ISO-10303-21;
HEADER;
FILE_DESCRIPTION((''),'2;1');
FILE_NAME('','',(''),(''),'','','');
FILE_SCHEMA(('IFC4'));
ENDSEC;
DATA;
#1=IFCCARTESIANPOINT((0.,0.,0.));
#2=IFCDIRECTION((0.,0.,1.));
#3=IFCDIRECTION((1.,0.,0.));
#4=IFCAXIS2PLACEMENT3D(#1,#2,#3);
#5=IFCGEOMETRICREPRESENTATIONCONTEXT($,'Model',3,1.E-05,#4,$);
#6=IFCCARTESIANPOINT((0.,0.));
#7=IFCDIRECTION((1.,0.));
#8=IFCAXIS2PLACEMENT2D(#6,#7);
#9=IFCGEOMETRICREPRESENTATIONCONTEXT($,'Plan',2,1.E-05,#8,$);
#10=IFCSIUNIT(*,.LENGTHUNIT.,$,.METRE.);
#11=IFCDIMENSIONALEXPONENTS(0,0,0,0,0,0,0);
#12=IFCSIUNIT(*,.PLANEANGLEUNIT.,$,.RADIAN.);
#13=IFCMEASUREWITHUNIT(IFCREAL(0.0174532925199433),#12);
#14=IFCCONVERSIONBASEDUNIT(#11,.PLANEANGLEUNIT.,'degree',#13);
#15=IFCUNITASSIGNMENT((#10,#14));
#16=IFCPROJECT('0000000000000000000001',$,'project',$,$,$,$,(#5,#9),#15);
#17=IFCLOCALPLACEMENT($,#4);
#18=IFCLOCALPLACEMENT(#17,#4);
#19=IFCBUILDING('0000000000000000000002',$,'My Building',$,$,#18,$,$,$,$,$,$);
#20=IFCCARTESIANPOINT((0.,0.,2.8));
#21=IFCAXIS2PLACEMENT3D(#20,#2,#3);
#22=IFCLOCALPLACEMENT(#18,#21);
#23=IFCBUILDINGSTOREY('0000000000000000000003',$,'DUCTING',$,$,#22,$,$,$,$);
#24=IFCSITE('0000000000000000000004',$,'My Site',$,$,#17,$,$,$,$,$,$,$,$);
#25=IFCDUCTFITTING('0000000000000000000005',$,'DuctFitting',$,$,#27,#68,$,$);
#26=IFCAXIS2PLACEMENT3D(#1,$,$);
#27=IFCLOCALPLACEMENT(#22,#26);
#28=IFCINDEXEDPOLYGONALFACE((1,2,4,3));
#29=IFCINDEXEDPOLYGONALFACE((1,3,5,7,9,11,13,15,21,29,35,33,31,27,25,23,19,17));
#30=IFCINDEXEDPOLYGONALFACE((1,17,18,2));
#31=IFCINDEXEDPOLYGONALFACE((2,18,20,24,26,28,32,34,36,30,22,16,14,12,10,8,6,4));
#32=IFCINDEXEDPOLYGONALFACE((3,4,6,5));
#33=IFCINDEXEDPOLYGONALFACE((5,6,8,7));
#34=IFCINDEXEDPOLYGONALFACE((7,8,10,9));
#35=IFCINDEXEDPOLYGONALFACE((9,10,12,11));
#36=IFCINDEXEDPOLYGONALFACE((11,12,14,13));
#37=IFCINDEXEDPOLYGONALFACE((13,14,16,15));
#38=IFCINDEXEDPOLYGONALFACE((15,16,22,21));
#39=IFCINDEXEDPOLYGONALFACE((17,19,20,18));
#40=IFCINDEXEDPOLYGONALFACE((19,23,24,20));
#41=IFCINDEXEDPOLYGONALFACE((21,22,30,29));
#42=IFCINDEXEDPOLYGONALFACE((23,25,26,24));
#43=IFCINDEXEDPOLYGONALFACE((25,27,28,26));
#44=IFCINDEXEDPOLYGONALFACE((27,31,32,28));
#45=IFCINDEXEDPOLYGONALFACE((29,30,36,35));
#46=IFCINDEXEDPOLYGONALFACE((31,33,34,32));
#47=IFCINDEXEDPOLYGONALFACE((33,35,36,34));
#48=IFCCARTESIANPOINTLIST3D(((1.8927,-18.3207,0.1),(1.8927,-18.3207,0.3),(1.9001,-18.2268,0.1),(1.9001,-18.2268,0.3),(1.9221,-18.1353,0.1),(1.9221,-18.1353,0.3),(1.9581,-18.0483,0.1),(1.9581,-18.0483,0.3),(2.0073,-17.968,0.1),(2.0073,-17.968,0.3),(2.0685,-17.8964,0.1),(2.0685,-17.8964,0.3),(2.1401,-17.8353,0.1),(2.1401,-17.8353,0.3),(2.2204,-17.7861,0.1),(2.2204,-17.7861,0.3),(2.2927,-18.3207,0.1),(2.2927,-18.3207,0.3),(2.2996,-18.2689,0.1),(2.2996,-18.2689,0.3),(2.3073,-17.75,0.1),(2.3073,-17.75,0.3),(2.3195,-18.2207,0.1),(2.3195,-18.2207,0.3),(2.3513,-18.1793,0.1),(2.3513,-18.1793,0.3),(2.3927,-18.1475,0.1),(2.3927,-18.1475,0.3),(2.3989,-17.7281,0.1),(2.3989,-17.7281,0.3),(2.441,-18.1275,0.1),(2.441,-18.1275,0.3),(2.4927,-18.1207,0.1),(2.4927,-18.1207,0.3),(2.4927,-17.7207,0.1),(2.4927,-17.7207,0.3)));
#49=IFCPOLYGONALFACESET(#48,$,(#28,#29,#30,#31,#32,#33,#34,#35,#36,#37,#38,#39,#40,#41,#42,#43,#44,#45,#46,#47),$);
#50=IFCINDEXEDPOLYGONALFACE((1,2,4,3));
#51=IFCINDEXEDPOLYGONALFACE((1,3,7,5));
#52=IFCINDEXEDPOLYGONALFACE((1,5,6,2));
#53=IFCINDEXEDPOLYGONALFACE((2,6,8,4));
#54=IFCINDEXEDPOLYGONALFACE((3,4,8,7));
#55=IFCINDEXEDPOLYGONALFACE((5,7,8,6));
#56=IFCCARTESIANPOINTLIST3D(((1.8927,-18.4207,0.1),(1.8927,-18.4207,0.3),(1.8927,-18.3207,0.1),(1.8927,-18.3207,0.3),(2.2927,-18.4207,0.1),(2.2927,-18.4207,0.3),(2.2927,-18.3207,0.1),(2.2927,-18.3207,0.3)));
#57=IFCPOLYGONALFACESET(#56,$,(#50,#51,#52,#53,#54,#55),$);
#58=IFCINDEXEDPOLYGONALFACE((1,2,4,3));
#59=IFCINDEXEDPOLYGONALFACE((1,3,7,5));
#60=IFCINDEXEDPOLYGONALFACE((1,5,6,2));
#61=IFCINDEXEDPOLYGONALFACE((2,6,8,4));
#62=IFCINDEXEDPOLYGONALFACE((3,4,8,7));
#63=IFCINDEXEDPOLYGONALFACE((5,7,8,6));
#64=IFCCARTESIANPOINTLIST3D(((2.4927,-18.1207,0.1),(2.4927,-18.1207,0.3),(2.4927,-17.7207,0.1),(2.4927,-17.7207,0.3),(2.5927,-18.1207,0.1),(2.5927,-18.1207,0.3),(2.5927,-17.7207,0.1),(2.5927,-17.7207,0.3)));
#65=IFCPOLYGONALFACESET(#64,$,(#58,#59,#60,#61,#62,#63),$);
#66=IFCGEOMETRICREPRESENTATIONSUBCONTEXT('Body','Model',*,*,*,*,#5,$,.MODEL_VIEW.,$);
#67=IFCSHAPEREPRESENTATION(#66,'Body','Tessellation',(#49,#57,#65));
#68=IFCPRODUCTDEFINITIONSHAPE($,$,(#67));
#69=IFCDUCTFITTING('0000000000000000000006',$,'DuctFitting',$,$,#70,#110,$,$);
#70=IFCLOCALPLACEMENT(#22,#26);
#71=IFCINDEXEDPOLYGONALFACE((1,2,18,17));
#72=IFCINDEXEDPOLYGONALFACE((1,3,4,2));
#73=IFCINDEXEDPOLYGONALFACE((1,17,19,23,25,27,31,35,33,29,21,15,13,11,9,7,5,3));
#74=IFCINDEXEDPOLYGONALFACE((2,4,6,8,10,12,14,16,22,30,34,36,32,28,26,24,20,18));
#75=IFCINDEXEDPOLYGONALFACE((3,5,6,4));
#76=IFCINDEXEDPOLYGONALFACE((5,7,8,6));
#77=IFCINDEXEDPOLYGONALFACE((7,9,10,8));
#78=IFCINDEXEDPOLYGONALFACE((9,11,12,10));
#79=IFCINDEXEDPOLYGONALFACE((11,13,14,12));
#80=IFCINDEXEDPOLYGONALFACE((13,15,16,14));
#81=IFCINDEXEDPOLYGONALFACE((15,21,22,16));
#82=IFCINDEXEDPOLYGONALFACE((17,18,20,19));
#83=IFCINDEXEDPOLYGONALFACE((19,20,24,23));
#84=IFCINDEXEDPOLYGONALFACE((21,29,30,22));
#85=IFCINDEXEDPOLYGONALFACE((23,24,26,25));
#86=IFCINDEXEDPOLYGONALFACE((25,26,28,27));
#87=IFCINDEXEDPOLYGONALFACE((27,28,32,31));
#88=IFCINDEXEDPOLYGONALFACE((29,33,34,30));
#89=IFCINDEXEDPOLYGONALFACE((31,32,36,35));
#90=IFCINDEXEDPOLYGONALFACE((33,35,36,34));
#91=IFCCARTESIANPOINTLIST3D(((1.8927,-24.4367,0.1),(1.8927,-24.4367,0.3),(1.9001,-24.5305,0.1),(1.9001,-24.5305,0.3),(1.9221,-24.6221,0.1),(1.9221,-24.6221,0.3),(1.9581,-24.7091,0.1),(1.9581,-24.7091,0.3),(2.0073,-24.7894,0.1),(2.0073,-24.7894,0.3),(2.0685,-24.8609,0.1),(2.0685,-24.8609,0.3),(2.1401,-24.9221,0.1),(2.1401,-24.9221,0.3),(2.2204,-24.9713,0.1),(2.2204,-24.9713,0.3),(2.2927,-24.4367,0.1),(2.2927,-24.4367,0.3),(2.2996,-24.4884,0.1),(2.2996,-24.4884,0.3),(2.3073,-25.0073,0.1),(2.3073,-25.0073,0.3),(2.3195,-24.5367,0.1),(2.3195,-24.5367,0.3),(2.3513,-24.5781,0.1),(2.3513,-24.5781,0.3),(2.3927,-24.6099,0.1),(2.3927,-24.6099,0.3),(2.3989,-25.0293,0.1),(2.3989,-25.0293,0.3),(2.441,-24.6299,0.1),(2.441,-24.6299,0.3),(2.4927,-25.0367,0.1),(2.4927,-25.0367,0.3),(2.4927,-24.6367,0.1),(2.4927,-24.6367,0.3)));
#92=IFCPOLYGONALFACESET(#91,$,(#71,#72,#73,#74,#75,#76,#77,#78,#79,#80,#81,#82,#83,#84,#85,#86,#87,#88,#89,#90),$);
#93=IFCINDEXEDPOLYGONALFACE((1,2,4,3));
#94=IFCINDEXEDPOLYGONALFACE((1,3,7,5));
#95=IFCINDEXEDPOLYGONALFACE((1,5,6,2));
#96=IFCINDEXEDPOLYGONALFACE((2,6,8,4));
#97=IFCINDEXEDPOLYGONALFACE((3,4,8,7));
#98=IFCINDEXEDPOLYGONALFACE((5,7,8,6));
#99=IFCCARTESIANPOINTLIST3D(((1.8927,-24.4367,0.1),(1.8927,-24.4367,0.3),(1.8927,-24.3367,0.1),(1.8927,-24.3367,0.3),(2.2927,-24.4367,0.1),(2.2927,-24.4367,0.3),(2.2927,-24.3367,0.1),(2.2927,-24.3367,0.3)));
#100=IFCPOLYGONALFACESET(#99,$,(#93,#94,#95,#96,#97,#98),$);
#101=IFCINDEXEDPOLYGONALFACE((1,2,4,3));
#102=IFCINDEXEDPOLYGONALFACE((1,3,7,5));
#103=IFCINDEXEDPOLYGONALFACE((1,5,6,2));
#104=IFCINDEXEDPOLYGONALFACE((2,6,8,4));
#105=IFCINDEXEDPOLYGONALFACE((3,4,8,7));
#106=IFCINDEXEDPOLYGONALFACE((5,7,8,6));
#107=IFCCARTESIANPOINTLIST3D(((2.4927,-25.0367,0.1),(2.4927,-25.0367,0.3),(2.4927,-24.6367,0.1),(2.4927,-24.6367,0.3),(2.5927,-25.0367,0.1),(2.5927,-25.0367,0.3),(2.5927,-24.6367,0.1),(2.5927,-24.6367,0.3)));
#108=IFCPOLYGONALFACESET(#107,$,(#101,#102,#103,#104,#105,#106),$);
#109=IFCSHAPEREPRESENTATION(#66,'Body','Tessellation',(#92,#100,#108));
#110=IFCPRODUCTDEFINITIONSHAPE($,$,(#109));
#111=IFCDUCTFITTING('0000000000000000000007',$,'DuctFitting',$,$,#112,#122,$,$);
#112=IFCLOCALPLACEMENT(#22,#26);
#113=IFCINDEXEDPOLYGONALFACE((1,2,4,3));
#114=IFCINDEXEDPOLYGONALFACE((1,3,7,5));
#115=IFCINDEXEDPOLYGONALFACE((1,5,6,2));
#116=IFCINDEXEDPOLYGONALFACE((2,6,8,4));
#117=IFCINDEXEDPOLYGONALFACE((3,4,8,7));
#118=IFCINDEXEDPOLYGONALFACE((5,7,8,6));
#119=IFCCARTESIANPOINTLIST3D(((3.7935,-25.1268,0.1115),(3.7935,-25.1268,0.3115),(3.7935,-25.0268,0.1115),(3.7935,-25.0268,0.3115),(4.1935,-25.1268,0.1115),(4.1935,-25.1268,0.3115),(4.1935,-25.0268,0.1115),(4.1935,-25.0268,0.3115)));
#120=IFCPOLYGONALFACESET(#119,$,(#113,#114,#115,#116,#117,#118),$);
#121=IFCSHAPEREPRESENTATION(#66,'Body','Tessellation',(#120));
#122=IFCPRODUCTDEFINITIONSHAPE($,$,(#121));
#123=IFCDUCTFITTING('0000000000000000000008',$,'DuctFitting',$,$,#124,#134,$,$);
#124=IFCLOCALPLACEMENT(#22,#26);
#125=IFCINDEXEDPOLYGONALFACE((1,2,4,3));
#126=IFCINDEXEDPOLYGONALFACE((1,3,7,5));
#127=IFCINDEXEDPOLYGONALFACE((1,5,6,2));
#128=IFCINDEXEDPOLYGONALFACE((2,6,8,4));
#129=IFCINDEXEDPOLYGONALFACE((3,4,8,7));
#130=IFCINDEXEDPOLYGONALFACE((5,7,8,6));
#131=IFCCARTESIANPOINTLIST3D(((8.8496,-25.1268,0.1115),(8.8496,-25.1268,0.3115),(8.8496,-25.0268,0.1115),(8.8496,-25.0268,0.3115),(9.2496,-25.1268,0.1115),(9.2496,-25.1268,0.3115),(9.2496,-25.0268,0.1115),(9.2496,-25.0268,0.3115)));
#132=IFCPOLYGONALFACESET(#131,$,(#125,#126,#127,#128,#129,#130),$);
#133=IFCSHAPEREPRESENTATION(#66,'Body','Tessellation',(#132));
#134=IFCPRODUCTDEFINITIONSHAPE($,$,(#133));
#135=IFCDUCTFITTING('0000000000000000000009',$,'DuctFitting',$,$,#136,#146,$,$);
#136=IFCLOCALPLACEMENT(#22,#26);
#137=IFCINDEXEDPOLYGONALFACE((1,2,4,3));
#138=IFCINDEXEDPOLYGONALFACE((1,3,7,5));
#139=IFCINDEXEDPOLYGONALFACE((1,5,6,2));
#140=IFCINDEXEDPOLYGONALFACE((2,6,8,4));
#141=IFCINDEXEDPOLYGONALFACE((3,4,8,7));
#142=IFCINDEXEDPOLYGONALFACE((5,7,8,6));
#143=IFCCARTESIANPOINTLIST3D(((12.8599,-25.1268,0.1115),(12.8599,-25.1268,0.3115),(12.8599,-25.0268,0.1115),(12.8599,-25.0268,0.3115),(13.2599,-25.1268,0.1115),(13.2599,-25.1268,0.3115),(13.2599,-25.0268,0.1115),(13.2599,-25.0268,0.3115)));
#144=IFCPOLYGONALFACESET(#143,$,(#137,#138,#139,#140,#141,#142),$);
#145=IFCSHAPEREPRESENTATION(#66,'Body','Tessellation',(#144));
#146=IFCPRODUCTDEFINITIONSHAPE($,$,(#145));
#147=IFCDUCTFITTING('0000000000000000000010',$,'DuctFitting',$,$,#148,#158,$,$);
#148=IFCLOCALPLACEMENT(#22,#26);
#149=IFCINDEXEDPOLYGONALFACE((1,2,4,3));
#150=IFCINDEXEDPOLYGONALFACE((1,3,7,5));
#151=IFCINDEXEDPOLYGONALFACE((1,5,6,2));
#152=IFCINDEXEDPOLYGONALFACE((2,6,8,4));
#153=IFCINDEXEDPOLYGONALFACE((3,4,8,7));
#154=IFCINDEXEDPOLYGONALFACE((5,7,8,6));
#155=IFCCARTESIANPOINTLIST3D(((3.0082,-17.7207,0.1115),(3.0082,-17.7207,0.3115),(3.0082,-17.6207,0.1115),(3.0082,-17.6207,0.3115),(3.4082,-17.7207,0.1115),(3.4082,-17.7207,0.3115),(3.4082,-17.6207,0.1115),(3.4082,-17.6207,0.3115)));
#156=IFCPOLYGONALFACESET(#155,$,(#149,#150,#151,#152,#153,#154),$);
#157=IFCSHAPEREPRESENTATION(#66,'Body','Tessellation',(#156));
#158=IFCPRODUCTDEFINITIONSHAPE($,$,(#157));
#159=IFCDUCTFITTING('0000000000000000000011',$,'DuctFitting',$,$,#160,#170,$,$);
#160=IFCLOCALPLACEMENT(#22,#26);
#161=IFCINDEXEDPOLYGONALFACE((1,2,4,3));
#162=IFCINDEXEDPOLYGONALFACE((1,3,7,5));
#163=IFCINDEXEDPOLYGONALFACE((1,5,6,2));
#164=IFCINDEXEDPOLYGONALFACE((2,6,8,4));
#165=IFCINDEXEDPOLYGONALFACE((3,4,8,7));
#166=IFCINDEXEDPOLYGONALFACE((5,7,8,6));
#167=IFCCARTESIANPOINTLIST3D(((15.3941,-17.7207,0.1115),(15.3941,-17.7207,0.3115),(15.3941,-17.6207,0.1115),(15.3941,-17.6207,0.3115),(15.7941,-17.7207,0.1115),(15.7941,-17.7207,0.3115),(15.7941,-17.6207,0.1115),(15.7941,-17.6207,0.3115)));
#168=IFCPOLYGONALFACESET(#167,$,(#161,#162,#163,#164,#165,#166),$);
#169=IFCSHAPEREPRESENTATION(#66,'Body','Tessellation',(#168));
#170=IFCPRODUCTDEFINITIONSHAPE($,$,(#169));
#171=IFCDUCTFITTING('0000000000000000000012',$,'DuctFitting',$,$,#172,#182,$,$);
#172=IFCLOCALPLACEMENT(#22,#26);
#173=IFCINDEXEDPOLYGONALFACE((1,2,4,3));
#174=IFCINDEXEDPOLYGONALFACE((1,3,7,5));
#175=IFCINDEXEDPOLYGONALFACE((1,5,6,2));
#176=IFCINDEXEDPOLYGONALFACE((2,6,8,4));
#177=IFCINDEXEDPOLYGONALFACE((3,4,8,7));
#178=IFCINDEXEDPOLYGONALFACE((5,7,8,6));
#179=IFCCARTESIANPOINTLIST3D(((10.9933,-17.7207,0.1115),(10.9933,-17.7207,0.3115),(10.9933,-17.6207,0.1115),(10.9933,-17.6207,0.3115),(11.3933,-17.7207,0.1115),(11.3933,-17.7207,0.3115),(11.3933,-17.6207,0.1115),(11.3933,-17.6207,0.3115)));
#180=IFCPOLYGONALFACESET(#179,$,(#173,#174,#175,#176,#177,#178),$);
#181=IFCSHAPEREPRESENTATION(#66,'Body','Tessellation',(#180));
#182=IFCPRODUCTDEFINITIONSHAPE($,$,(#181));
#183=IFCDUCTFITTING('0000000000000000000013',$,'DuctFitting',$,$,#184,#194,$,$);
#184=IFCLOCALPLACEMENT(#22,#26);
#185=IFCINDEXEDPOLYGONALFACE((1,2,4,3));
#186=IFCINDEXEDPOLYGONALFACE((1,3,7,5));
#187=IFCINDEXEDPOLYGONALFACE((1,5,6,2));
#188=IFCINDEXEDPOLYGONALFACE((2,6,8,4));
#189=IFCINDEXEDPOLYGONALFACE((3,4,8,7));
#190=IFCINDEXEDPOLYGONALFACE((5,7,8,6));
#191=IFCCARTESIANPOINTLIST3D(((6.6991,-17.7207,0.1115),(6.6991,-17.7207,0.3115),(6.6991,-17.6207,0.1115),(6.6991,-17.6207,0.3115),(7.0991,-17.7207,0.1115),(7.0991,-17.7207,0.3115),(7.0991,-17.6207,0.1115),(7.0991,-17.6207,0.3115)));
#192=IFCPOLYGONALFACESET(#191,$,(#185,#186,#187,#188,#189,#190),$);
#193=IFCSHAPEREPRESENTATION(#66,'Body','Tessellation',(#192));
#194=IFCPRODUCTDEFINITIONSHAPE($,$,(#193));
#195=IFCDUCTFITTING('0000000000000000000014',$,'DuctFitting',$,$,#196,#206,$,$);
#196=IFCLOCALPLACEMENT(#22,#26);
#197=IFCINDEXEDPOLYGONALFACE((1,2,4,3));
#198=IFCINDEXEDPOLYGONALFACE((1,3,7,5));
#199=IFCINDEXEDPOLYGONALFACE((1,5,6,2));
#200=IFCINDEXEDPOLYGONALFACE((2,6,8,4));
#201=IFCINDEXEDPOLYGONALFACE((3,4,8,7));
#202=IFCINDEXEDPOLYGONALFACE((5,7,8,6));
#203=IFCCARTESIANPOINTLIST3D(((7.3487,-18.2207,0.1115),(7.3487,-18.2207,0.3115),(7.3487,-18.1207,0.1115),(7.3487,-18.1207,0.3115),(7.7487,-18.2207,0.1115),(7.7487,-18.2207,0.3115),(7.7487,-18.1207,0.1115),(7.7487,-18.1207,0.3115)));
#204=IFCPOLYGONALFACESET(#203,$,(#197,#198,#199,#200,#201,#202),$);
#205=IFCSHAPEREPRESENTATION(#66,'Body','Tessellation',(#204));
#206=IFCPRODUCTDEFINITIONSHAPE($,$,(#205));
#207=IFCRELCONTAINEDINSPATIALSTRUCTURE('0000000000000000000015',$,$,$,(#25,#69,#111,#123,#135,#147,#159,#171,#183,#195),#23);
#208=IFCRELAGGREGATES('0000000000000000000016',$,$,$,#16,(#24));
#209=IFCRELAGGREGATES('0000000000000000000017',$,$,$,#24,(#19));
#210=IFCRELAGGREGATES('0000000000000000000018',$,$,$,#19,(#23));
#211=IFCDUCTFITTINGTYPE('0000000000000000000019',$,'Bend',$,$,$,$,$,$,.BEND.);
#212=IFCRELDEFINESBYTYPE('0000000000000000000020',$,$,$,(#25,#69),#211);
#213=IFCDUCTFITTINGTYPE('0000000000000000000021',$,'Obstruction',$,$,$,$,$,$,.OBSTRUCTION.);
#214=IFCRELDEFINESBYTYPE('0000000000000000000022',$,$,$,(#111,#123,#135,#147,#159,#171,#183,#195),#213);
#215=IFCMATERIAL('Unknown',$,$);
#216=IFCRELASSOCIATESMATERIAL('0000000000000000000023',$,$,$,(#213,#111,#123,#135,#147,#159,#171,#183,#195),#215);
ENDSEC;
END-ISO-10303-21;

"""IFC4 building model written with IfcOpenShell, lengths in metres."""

from ifc_helpers import new_model, entity, si_unit, converted_unit, frame, origin_with_axes, origin_2d_with_axis, place, context, subcontext, project, spatial, line, arc, indexed_curve, rectangle, outline, extrude, source, transform, mapped, material, material_profile, profile_set, profile_usage, type_object, type_shapes, element, save


model = new_model("IFC4")

# Units and contexts
model_context = context("Model", 3, precision=1e-05, world=origin_with_axes())
plan_context = context("Plan", 2, precision=1e-05, world=origin_2d_with_axis())
body_context = subcontext(model_context, "Body", "Model", "MODEL_VIEW")
ifc_project = project(units=[si_unit("LENGTHUNIT", "METRE"), converted_unit("PLANEANGLEUNIT", "degree", entity("IfcReal", 0.0174532925199433), si_unit("PLANEANGLEUNIT", "RADIAN"), dimensions=[0, 0, 0, 0, 0, 0, 0])], contexts=[model_context, plan_context])

# Site, building, storey
site_placement = place(None, origin_with_axes())
site = spatial("IfcSite", under=ifc_project, at=site_placement, Name="My Site")
building_placement = place(site_placement, origin_with_axes())
building = spatial("IfcBuilding", under=site, at=building_placement, Name="My Building")
storey_placement = place(building_placement, frame((0.0, 0.0, 2.8), z_axis=(0.0, 0.0, 1.0), x_axis=(1.0, 0.0, 0.0)))
storey = spatial("IfcBuildingStorey", under=building, at=storey_placement, Name="DUCTING")

# Shared definitions
ifc_material = material(Name="Unknown")

# Duct fittings
duct_fitting_type_1 = type_object("IfcDuctFittingType", Name="Bend", PredefinedType="BEND")
shared_shape = source(origin_with_axes(), body_context, "Body", "SweptSolid", [
    extrude(outline(indexed_curve([(-0.2, 0.0), (-0.2586, -0.1414), (-0.4, -0.2), (-0.4, -0.6), (0.0243, -0.4243), (0.2, 0.0)], segments=[arc(1, 2, 3), line(3, 4), arc(4, 5, 6), line(6, 1)])), frame((0.0, -0.1, -0.1), z_axis=(0.0, -1.0, 0.0), x_axis=(1.0, 0.0, 0.0)), (0.0, 0.0, -1.0), 0.2),
    extrude(rectangle(XDim=0.4, YDim=0.2), origin_with_axes(), (0.0, 0.0, -1.0), 0.1),
    extrude(rectangle(XDim=0.4, YDim=0.2), frame((-0.4, 0.0, -0.5), z_axis=(-1.0, 0.0, 0.0), x_axis=(0.0, 0.0, -1.0)), (0.0, 0.0, 1.0), 0.1),
])
type_shapes(duct_fitting_type_1, [shared_shape])
for number, where, z_axis, x_axis, name in (
    (1, (2.0927, -18.4207, 0.2), (0.0, -1.0, 0.0), (-1.0, 0.0, 0.0), "DuctFitting"),
    (2, (2.0927, -24.3367, 0.2), (0.0, 1.0, 0.0), (-1.0, 0.0, 0.0), "DuctFitting"),
):
    element("IfcDuctFitting", number, at=place(storey_placement, frame(where, z_axis=z_axis, x_axis=x_axis)), inside=storey, type_object=duct_fitting_type_1, Name=name, context=body_context, shape_type="MappedRepresentation", body=[
        mapped(shared_shape, transform((0.0, 0.0, 0.0), x_axis=(1.0, 0.0, 0.0), y_axis=(0.0, 1.0, 0.0), z_axis=(0.0, 0.0, 1.0), scale=1.0)),
    ])
ifc_material_profile_1 = material_profile(ifc_material, rectangle(XDim=0.4, YDim=0.2))
ifc_profile_set_1 = profile_set([ifc_material_profile_1])
ifc_profile_usage_1 = profile_usage(ifc_profile_set_1, cardinal=5)
duct_fitting_type_2 = type_object("IfcDuctFittingType", Name="Obstruction", PredefinedType="OBSTRUCTION", material=ifc_profile_set_1)
duct_fitting_1_placement = place(storey_placement, frame((3.9935, -25.0268, 0.2115), z_axis=(-0.000018, -1.0, 0.000001), x_axis=(1.0, -0.000018, 0.0)))
element("IfcDuctFitting", 3, at=duct_fitting_1_placement, inside=storey, type_object=duct_fitting_type_2, material=ifc_profile_usage_1, Name="DuctFitting", context=body_context, shape_type="SweptSolid", body=[
    extrude(rectangle(XDim=0.4, YDim=0.2), origin_with_axes(), (0.0, 0.0, 1.0), 0.1),
])
ifc_profile_usage_2 = profile_usage(ifc_profile_set_1, cardinal=5)
duct_fitting_2_placement = place(storey_placement, frame((9.0496, -25.0268, 0.2115), z_axis=(-0.000018, -1.0, 0.000001), x_axis=(1.0, -0.000018, 0.0)))
element("IfcDuctFitting", 4, at=duct_fitting_2_placement, inside=storey, type_object=duct_fitting_type_2, material=ifc_profile_usage_2, Name="DuctFitting", context=body_context, shape_type="SweptSolid", body=[
    extrude(rectangle(XDim=0.4, YDim=0.2), origin_with_axes(), (0.0, 0.0, 1.0), 0.1),
])
ifc_profile_usage_3 = profile_usage(ifc_profile_set_1, cardinal=5)
duct_fitting_3_placement = place(storey_placement, frame((13.0599, -25.0268, 0.2115), z_axis=(-0.000018, -1.0, 0.000001), x_axis=(1.0, -0.000018, 0.0)))
element("IfcDuctFitting", 5, at=duct_fitting_3_placement, inside=storey, type_object=duct_fitting_type_2, material=ifc_profile_usage_3, Name="DuctFitting", context=body_context, shape_type="SweptSolid", body=[
    extrude(rectangle(XDim=0.4, YDim=0.2), origin_with_axes(), (0.0, 0.0, 1.0), 0.1),
])
ifc_profile_usage_4 = profile_usage(ifc_profile_set_1, cardinal=5)
duct_fitting_4_placement = place(storey_placement, frame((3.2082, -17.7207, 0.2115), z_axis=(0.000018, 1.0, 0.000001), x_axis=(-1.0, 0.000018, 0.0)))
element("IfcDuctFitting", 6, at=duct_fitting_4_placement, inside=storey, type_object=duct_fitting_type_2, material=ifc_profile_usage_4, Name="DuctFitting", context=body_context, shape_type="SweptSolid", body=[
    extrude(rectangle(XDim=0.4, YDim=0.2), origin_with_axes(), (0.0, 0.0, 1.0), 0.1),
])
ifc_profile_usage_5 = profile_usage(ifc_profile_set_1, cardinal=5)
duct_fitting_5_placement = place(storey_placement, frame((15.5941, -17.7207, 0.2115), z_axis=(0.000018, 1.0, 0.000001), x_axis=(-1.0, 0.000018, 0.0)))
element("IfcDuctFitting", 7, at=duct_fitting_5_placement, inside=storey, type_object=duct_fitting_type_2, material=ifc_profile_usage_5, Name="DuctFitting", context=body_context, shape_type="SweptSolid", body=[
    extrude(rectangle(XDim=0.4, YDim=0.2), origin_with_axes(), (0.0, 0.0, 1.0), 0.1),
])
ifc_profile_usage_6 = profile_usage(ifc_profile_set_1, cardinal=5)
duct_fitting_6_placement = place(storey_placement, frame((11.1933, -17.7207, 0.2115), z_axis=(0.000018, 1.0, 0.000001), x_axis=(-1.0, 0.000018, 0.0)))
element("IfcDuctFitting", 8, at=duct_fitting_6_placement, inside=storey, type_object=duct_fitting_type_2, material=ifc_profile_usage_6, Name="DuctFitting", context=body_context, shape_type="SweptSolid", body=[
    extrude(rectangle(XDim=0.4, YDim=0.2), origin_with_axes(), (0.0, 0.0, 1.0), 0.1),
])
ifc_profile_usage_7 = profile_usage(ifc_profile_set_1, cardinal=5)
duct_fitting_7_placement = place(storey_placement, frame((6.8991, -17.7207, 0.2115), z_axis=(0.000018, 1.0, 0.000001), x_axis=(-1.0, 0.000018, 0.0)))
element("IfcDuctFitting", 9, at=duct_fitting_7_placement, inside=storey, type_object=duct_fitting_type_2, material=ifc_profile_usage_7, Name="DuctFitting", context=body_context, shape_type="SweptSolid", body=[
    extrude(rectangle(XDim=0.4, YDim=0.2), origin_with_axes(), (0.0, 0.0, 1.0), 0.1),
])
ifc_profile_usage_8 = profile_usage(ifc_profile_set_1, cardinal=5)
duct_fitting_8_placement = place(storey_placement, frame((7.5487, -18.1207, 0.2115), z_axis=(-0.000018, -1.0, 0.000001), x_axis=(1.0, -0.000018, 0.0)))
element("IfcDuctFitting", 10, at=duct_fitting_8_placement, inside=storey, type_object=duct_fitting_type_2, material=ifc_profile_usage_8, Name="DuctFitting", context=body_context, shape_type="SweptSolid", body=[
    extrude(rectangle(XDim=0.4, YDim=0.2), origin_with_axes(), (0.0, 0.0, 1.0), 0.1),
])

save(model, "model.ifc")
